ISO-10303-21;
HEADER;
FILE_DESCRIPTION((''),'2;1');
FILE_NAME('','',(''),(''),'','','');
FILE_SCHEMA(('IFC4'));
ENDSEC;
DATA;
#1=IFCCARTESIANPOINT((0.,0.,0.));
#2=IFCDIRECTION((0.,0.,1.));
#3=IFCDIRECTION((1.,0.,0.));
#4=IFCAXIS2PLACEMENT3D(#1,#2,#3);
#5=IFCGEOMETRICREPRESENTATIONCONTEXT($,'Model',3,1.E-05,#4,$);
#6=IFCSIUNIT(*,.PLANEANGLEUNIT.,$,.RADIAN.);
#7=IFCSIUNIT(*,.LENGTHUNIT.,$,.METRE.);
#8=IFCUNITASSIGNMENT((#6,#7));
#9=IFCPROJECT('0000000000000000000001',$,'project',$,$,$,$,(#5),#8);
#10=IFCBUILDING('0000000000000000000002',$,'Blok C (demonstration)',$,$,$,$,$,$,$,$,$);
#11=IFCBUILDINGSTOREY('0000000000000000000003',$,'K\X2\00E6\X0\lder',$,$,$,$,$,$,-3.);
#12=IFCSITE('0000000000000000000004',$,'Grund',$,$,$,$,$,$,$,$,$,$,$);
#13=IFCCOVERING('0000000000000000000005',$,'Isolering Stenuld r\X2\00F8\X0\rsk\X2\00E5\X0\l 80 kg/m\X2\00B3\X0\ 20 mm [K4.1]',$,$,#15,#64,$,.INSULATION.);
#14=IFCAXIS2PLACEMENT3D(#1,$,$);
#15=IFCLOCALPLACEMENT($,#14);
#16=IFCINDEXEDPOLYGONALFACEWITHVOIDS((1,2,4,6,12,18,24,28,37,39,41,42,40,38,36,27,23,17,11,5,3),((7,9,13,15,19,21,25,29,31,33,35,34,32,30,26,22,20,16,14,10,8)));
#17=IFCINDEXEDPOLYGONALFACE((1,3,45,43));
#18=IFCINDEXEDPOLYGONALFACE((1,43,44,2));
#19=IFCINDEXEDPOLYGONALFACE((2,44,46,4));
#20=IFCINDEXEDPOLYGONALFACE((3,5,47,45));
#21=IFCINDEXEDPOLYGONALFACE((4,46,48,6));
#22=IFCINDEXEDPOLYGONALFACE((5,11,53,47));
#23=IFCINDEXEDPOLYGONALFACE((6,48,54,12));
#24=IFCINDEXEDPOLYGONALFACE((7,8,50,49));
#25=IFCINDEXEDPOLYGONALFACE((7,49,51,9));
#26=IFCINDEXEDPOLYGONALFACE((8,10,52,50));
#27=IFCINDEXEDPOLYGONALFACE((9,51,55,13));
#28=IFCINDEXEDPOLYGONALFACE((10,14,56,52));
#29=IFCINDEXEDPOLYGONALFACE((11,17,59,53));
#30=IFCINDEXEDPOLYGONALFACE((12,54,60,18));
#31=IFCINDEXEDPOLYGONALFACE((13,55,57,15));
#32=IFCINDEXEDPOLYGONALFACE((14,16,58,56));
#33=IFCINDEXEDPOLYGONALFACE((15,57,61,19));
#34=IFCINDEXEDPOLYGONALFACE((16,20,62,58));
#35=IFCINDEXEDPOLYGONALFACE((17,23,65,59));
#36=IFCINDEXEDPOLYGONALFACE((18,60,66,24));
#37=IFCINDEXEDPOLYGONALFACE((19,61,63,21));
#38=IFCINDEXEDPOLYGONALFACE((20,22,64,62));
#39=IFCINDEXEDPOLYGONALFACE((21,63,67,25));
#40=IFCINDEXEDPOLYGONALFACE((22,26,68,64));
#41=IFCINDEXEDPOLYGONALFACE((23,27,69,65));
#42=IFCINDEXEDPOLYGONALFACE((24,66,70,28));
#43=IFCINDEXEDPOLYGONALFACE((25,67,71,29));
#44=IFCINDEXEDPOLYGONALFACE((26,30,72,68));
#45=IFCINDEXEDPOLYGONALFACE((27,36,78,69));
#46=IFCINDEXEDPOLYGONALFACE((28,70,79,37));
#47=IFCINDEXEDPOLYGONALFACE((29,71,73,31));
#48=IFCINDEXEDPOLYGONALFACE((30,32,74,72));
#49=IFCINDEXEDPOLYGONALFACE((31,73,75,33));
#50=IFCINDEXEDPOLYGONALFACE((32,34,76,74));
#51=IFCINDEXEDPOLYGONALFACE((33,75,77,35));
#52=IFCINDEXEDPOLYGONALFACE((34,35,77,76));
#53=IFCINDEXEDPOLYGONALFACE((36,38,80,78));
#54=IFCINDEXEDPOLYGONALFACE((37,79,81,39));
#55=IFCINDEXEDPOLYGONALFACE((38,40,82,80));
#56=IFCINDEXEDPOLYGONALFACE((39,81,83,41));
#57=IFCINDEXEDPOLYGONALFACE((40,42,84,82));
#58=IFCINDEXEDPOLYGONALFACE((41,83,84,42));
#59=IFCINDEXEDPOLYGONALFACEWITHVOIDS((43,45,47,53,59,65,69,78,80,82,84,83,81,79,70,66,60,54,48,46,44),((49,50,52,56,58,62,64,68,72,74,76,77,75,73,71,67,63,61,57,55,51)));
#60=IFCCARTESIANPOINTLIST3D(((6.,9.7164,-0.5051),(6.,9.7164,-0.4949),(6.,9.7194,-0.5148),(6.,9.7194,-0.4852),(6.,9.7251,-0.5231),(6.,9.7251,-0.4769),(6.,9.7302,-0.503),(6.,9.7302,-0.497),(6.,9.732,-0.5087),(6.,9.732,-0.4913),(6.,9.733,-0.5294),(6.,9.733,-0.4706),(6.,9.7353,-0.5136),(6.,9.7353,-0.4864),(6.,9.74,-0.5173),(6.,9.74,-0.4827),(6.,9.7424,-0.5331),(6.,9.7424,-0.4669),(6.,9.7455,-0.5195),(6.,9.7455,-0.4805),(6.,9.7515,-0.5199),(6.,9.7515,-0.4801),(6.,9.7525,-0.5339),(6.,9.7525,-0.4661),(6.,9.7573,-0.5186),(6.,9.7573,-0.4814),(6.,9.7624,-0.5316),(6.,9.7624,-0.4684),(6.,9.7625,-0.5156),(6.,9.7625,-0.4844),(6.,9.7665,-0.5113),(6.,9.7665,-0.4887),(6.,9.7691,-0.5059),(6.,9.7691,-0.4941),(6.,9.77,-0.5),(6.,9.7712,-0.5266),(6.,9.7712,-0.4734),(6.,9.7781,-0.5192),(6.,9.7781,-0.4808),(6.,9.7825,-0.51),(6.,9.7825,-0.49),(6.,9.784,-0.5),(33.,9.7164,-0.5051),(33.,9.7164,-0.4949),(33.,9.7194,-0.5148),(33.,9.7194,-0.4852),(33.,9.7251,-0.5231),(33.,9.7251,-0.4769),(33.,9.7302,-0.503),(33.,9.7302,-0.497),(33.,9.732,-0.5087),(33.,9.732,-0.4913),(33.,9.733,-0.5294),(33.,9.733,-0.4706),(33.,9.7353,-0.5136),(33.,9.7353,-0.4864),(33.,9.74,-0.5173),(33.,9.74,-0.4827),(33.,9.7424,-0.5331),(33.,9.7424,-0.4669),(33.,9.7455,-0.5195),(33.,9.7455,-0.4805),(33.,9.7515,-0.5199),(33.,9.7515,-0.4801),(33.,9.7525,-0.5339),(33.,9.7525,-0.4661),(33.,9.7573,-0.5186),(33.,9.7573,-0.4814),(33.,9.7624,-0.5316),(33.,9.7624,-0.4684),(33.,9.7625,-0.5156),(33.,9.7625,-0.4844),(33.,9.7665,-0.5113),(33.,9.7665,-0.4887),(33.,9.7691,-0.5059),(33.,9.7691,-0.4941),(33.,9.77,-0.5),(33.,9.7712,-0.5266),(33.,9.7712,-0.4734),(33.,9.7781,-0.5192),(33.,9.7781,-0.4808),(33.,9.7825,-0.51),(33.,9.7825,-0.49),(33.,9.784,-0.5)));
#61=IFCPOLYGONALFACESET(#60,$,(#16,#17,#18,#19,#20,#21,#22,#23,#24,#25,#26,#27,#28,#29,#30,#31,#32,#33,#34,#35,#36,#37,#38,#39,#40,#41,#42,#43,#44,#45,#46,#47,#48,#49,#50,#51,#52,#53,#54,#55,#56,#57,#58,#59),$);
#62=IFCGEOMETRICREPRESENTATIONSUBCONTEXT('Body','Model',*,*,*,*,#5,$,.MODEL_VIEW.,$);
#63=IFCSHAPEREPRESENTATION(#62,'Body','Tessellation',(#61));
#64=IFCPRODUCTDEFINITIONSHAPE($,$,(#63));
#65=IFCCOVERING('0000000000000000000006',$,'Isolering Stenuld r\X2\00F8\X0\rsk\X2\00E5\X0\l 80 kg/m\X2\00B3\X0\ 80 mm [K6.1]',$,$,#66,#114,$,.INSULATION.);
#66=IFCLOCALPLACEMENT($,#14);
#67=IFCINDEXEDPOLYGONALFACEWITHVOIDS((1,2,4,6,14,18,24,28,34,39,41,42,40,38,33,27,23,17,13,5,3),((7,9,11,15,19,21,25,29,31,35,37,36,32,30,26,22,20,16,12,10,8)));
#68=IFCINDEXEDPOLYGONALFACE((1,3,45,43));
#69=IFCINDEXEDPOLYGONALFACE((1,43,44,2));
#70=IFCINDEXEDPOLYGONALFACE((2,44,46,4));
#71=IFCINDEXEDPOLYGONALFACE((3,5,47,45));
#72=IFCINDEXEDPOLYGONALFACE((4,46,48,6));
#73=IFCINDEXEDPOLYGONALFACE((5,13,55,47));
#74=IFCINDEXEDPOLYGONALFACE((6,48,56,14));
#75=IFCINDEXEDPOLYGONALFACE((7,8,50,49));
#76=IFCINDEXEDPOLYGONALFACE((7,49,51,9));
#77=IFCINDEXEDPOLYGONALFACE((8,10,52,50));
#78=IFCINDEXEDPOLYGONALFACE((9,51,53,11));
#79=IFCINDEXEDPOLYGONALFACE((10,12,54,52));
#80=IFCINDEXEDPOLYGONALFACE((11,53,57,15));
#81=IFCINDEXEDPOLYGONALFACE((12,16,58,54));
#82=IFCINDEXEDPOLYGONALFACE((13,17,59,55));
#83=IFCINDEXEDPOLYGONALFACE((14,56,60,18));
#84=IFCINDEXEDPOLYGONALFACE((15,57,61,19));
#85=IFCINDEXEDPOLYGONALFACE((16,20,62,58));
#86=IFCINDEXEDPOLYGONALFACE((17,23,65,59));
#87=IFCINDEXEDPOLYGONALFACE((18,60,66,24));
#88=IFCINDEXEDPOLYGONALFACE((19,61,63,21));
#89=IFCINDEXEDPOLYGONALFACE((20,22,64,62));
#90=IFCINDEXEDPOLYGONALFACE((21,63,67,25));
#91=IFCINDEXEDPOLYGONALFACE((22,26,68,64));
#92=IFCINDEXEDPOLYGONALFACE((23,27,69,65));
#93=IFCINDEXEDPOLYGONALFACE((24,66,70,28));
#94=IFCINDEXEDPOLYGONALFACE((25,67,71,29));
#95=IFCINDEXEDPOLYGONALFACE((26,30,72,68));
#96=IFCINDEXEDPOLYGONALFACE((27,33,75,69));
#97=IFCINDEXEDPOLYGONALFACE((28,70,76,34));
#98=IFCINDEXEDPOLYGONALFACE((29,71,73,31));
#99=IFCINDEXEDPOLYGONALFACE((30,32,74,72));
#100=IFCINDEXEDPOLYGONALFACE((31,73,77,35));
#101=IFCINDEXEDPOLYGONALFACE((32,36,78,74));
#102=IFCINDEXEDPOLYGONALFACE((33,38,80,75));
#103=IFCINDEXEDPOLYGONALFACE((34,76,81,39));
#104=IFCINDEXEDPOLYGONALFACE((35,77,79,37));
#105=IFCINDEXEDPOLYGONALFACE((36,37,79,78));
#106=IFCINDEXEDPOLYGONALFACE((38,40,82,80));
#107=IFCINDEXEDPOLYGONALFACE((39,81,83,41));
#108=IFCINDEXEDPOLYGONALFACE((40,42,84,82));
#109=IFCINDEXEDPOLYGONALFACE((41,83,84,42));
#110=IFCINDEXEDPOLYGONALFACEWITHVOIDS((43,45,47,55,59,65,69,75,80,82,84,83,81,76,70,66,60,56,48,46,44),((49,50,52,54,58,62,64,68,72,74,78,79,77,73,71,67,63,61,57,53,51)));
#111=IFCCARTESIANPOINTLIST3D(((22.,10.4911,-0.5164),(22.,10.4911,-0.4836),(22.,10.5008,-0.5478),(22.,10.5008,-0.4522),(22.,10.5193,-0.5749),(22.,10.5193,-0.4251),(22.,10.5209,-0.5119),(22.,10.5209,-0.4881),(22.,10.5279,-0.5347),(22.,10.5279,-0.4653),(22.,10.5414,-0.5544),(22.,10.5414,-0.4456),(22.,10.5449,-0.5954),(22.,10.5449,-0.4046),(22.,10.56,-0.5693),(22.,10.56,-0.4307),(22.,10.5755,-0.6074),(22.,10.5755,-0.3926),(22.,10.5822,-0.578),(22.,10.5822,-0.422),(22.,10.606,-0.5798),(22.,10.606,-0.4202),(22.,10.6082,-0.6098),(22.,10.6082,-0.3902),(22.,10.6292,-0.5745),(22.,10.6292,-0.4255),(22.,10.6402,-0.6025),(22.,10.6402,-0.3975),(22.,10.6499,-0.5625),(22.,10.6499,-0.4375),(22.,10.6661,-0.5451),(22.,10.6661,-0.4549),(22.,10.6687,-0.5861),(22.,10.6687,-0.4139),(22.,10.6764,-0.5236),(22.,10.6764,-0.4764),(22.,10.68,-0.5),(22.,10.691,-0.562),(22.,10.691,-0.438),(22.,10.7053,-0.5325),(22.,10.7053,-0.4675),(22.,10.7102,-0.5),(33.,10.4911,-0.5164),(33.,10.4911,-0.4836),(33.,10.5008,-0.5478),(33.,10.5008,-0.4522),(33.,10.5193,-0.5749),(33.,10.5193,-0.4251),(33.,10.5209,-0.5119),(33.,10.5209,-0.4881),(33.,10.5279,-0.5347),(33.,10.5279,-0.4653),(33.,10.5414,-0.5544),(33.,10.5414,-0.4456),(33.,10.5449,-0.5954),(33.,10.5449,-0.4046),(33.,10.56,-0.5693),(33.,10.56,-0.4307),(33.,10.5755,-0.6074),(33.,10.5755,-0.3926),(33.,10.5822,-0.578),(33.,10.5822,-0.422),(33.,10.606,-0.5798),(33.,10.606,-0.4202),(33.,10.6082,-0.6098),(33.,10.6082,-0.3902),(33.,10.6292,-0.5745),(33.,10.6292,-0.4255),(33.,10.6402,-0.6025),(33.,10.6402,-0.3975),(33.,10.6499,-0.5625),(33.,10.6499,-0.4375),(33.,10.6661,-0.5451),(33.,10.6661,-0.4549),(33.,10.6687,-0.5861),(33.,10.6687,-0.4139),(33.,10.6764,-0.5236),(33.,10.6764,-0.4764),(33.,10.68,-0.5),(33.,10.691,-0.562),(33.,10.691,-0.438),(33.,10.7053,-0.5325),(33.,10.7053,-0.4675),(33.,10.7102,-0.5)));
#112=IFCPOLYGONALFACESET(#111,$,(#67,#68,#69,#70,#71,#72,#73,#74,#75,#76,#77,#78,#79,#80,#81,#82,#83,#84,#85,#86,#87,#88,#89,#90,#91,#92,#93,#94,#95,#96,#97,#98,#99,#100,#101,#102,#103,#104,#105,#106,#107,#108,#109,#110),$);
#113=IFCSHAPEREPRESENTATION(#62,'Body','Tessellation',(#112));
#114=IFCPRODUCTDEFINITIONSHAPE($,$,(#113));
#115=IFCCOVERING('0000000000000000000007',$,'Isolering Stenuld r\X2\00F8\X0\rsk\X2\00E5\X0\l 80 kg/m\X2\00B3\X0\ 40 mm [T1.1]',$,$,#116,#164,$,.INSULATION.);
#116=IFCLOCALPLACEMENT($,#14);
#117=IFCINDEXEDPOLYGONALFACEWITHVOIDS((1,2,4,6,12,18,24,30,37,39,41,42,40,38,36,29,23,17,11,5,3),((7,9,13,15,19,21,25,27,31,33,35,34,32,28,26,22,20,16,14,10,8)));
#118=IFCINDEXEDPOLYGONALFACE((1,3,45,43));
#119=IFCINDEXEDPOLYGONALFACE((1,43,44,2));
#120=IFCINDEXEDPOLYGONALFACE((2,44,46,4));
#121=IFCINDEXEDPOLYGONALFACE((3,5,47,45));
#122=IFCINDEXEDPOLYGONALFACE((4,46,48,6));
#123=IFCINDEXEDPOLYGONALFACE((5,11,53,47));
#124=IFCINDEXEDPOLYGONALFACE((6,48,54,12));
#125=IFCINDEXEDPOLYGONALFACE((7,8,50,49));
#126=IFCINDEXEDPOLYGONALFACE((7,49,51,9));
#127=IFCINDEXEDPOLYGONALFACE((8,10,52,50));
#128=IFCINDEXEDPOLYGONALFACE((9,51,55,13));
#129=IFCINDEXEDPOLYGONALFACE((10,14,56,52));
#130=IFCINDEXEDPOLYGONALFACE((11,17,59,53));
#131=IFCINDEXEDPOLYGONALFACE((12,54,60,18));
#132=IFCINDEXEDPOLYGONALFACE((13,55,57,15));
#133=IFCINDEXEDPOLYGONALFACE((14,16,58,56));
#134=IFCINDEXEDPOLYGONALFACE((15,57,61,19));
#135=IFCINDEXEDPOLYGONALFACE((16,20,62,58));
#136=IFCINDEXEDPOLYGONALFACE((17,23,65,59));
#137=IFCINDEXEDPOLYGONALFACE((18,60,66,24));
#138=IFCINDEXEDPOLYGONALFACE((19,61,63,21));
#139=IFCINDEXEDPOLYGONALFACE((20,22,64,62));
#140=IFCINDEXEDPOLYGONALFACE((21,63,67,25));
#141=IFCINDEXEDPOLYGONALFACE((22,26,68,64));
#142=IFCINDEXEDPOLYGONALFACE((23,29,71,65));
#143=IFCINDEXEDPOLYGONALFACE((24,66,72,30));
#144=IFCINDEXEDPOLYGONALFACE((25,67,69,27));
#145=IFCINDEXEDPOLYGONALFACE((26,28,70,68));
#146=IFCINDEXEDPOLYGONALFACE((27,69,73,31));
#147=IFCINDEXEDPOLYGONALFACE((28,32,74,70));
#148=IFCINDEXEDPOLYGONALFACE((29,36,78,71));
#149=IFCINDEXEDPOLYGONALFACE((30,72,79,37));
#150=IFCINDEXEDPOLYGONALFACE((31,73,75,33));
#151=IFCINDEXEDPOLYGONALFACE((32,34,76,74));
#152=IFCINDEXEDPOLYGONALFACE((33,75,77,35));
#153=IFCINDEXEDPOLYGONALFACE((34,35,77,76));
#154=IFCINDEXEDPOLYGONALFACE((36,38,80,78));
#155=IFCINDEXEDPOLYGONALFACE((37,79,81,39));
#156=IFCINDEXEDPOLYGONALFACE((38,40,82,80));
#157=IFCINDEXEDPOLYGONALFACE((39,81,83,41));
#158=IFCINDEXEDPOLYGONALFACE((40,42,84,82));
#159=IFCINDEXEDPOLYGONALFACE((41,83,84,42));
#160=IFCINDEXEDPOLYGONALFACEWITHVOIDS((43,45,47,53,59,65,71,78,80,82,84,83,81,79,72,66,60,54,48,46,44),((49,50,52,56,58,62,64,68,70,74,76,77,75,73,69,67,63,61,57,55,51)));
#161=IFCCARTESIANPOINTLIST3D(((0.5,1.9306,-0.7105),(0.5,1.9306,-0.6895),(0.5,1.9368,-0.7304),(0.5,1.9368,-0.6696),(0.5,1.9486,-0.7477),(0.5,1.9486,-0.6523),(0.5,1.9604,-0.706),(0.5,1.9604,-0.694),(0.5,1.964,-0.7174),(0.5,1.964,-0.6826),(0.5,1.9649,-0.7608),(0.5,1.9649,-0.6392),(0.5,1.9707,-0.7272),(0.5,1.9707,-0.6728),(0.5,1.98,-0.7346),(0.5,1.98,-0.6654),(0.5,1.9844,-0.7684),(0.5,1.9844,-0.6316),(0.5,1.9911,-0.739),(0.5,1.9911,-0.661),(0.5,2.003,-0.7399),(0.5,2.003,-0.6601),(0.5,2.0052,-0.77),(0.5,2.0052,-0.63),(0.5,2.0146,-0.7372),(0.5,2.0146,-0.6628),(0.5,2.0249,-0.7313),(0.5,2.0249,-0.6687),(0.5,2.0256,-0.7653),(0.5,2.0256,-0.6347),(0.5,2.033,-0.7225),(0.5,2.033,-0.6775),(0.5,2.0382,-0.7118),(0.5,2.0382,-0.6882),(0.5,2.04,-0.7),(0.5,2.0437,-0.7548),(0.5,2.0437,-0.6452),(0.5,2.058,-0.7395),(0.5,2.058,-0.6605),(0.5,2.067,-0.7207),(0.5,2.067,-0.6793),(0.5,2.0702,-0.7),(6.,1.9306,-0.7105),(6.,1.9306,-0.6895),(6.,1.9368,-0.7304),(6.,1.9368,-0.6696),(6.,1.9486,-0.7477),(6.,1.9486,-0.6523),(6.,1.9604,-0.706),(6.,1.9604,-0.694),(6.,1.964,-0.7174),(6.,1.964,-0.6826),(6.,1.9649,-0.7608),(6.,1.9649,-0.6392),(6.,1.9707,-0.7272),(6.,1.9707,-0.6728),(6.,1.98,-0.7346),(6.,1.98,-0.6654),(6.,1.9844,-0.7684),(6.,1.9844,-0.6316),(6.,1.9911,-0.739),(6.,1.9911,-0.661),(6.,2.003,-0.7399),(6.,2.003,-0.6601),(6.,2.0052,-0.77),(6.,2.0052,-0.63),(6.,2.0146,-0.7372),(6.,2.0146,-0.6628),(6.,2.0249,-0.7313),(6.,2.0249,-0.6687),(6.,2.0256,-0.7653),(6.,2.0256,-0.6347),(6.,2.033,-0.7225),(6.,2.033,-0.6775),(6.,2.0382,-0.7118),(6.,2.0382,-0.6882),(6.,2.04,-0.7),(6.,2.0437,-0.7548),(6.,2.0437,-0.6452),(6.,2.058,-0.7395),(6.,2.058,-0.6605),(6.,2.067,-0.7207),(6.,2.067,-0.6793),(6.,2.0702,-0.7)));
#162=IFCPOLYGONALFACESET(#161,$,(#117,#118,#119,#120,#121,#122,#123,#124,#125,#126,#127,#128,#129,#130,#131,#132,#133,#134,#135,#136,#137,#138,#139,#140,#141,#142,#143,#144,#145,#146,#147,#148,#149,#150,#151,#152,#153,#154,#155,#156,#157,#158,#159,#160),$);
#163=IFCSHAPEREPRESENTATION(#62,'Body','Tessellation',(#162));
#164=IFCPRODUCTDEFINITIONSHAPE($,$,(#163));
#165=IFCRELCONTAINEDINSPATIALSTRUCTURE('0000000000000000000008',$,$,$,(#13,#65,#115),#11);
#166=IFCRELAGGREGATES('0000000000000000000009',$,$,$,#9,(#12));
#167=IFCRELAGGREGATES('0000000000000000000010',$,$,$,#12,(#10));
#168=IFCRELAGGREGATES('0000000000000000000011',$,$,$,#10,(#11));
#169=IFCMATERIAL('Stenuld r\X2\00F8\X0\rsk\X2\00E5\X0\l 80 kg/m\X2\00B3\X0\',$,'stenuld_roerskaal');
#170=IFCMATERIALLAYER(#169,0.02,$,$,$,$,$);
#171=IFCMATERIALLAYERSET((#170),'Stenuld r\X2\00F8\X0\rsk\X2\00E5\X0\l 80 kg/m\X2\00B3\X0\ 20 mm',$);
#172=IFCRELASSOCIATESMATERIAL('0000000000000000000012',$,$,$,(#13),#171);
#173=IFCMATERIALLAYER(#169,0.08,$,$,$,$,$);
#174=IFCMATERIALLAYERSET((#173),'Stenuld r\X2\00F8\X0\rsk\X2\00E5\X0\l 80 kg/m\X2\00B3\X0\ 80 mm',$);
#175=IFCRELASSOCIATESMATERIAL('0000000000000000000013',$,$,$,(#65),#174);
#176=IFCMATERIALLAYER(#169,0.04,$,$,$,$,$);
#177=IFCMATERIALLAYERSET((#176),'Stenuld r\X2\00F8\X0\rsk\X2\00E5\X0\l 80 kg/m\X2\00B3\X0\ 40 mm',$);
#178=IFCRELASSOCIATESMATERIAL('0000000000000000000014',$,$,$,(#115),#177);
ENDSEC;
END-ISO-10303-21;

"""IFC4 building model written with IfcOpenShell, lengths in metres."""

from ifc_helpers import new_model, si_unit, frame, origin_with_axes, place, context, subcontext, project, spatial, hollow_circle, extrude, material, layer, layer_set, element, save


model = new_model("IFC4")

# Units and contexts
model_context = context("Model", 3, precision=1e-05, world=origin_with_axes())
body_context = subcontext(model_context, "Body", "Model", "MODEL_VIEW")
ifc_project = project(units=[si_unit("PLANEANGLEUNIT", "RADIAN"), si_unit("LENGTHUNIT", "METRE")], contexts=[model_context])

# Site, building, storey
site = spatial("IfcSite", under=ifc_project, Name="Grund")
building = spatial("IfcBuilding", under=site, Name="Blok C (demonstration)")
storey = spatial("IfcBuildingStorey", under=building, Name="Kælder", Elevation=-3.0)

# Coverings
ifc_material_1 = material(Name="Stenuld rørskål 80 kg/m³", Category="stenuld_roerskaal")
ifc_layer_1 = layer(ifc_material_1, 0.02)
ifc_layer_set_1 = layer_set([ifc_layer_1], Name="Stenuld rørskål 80 kg/m³ 20 mm")
covering_1_placement = place(None, origin_with_axes())
element("IfcCovering", 1, at=covering_1_placement, inside=storey, material=ifc_layer_set_1, Name="Isolering Stenuld rørskål 80 kg/m³ 20 mm [K4.1]", PredefinedType="INSULATION", context=body_context, shape_type="SweptSolid", body=[
    extrude(hollow_circle(Radius=0.034, WallThickness=0.014), frame((6.0, 9.75, -0.5), z_axis=(1.0, 0.0, 0.0), x_axis=(0.0, 1.0, 0.0)), (0.0, 0.0, 1.0), 27.0),
])
ifc_layer_2 = layer(ifc_material_1, 0.08)
ifc_layer_set_2 = layer_set([ifc_layer_2], Name="Stenuld rørskål 80 kg/m³ 80 mm")
covering_2_placement = place(None, origin_with_axes())
element("IfcCovering", 2, at=covering_2_placement, inside=storey, material=ifc_layer_set_2, Name="Isolering Stenuld rørskål 80 kg/m³ 80 mm [K6.1]", PredefinedType="INSULATION", context=body_context, shape_type="SweptSolid", body=[
    extrude(hollow_circle(Radius=0.1101, WallThickness=0.0301), frame((22.0, 10.6, -0.5), z_axis=(1.0, 0.0, 0.0), x_axis=(0.0, 1.0, 0.0)), (0.0, 0.0, 1.0), 11.0),
])
ifc_layer_3 = layer(ifc_material_1, 0.04)
ifc_layer_set_3 = layer_set([ifc_layer_3], Name="Stenuld rørskål 80 kg/m³ 40 mm")
covering_3_placement = place(None, origin_with_axes())
element("IfcCovering", 3, at=covering_3_placement, inside=storey, material=ifc_layer_set_3, Name="Isolering Stenuld rørskål 80 kg/m³ 40 mm [T1.1]", PredefinedType="INSULATION", context=body_context, shape_type="SweptSolid", body=[
    extrude(hollow_circle(Radius=0.0702, WallThickness=0.0302), frame((0.5, 2.0, -0.7), z_axis=(1.0, 0.0, 0.0), x_axis=(0.0, 1.0, 0.0)), (0.0, 0.0, 1.0), 5.5),
])

save(model, "model.ifc")
